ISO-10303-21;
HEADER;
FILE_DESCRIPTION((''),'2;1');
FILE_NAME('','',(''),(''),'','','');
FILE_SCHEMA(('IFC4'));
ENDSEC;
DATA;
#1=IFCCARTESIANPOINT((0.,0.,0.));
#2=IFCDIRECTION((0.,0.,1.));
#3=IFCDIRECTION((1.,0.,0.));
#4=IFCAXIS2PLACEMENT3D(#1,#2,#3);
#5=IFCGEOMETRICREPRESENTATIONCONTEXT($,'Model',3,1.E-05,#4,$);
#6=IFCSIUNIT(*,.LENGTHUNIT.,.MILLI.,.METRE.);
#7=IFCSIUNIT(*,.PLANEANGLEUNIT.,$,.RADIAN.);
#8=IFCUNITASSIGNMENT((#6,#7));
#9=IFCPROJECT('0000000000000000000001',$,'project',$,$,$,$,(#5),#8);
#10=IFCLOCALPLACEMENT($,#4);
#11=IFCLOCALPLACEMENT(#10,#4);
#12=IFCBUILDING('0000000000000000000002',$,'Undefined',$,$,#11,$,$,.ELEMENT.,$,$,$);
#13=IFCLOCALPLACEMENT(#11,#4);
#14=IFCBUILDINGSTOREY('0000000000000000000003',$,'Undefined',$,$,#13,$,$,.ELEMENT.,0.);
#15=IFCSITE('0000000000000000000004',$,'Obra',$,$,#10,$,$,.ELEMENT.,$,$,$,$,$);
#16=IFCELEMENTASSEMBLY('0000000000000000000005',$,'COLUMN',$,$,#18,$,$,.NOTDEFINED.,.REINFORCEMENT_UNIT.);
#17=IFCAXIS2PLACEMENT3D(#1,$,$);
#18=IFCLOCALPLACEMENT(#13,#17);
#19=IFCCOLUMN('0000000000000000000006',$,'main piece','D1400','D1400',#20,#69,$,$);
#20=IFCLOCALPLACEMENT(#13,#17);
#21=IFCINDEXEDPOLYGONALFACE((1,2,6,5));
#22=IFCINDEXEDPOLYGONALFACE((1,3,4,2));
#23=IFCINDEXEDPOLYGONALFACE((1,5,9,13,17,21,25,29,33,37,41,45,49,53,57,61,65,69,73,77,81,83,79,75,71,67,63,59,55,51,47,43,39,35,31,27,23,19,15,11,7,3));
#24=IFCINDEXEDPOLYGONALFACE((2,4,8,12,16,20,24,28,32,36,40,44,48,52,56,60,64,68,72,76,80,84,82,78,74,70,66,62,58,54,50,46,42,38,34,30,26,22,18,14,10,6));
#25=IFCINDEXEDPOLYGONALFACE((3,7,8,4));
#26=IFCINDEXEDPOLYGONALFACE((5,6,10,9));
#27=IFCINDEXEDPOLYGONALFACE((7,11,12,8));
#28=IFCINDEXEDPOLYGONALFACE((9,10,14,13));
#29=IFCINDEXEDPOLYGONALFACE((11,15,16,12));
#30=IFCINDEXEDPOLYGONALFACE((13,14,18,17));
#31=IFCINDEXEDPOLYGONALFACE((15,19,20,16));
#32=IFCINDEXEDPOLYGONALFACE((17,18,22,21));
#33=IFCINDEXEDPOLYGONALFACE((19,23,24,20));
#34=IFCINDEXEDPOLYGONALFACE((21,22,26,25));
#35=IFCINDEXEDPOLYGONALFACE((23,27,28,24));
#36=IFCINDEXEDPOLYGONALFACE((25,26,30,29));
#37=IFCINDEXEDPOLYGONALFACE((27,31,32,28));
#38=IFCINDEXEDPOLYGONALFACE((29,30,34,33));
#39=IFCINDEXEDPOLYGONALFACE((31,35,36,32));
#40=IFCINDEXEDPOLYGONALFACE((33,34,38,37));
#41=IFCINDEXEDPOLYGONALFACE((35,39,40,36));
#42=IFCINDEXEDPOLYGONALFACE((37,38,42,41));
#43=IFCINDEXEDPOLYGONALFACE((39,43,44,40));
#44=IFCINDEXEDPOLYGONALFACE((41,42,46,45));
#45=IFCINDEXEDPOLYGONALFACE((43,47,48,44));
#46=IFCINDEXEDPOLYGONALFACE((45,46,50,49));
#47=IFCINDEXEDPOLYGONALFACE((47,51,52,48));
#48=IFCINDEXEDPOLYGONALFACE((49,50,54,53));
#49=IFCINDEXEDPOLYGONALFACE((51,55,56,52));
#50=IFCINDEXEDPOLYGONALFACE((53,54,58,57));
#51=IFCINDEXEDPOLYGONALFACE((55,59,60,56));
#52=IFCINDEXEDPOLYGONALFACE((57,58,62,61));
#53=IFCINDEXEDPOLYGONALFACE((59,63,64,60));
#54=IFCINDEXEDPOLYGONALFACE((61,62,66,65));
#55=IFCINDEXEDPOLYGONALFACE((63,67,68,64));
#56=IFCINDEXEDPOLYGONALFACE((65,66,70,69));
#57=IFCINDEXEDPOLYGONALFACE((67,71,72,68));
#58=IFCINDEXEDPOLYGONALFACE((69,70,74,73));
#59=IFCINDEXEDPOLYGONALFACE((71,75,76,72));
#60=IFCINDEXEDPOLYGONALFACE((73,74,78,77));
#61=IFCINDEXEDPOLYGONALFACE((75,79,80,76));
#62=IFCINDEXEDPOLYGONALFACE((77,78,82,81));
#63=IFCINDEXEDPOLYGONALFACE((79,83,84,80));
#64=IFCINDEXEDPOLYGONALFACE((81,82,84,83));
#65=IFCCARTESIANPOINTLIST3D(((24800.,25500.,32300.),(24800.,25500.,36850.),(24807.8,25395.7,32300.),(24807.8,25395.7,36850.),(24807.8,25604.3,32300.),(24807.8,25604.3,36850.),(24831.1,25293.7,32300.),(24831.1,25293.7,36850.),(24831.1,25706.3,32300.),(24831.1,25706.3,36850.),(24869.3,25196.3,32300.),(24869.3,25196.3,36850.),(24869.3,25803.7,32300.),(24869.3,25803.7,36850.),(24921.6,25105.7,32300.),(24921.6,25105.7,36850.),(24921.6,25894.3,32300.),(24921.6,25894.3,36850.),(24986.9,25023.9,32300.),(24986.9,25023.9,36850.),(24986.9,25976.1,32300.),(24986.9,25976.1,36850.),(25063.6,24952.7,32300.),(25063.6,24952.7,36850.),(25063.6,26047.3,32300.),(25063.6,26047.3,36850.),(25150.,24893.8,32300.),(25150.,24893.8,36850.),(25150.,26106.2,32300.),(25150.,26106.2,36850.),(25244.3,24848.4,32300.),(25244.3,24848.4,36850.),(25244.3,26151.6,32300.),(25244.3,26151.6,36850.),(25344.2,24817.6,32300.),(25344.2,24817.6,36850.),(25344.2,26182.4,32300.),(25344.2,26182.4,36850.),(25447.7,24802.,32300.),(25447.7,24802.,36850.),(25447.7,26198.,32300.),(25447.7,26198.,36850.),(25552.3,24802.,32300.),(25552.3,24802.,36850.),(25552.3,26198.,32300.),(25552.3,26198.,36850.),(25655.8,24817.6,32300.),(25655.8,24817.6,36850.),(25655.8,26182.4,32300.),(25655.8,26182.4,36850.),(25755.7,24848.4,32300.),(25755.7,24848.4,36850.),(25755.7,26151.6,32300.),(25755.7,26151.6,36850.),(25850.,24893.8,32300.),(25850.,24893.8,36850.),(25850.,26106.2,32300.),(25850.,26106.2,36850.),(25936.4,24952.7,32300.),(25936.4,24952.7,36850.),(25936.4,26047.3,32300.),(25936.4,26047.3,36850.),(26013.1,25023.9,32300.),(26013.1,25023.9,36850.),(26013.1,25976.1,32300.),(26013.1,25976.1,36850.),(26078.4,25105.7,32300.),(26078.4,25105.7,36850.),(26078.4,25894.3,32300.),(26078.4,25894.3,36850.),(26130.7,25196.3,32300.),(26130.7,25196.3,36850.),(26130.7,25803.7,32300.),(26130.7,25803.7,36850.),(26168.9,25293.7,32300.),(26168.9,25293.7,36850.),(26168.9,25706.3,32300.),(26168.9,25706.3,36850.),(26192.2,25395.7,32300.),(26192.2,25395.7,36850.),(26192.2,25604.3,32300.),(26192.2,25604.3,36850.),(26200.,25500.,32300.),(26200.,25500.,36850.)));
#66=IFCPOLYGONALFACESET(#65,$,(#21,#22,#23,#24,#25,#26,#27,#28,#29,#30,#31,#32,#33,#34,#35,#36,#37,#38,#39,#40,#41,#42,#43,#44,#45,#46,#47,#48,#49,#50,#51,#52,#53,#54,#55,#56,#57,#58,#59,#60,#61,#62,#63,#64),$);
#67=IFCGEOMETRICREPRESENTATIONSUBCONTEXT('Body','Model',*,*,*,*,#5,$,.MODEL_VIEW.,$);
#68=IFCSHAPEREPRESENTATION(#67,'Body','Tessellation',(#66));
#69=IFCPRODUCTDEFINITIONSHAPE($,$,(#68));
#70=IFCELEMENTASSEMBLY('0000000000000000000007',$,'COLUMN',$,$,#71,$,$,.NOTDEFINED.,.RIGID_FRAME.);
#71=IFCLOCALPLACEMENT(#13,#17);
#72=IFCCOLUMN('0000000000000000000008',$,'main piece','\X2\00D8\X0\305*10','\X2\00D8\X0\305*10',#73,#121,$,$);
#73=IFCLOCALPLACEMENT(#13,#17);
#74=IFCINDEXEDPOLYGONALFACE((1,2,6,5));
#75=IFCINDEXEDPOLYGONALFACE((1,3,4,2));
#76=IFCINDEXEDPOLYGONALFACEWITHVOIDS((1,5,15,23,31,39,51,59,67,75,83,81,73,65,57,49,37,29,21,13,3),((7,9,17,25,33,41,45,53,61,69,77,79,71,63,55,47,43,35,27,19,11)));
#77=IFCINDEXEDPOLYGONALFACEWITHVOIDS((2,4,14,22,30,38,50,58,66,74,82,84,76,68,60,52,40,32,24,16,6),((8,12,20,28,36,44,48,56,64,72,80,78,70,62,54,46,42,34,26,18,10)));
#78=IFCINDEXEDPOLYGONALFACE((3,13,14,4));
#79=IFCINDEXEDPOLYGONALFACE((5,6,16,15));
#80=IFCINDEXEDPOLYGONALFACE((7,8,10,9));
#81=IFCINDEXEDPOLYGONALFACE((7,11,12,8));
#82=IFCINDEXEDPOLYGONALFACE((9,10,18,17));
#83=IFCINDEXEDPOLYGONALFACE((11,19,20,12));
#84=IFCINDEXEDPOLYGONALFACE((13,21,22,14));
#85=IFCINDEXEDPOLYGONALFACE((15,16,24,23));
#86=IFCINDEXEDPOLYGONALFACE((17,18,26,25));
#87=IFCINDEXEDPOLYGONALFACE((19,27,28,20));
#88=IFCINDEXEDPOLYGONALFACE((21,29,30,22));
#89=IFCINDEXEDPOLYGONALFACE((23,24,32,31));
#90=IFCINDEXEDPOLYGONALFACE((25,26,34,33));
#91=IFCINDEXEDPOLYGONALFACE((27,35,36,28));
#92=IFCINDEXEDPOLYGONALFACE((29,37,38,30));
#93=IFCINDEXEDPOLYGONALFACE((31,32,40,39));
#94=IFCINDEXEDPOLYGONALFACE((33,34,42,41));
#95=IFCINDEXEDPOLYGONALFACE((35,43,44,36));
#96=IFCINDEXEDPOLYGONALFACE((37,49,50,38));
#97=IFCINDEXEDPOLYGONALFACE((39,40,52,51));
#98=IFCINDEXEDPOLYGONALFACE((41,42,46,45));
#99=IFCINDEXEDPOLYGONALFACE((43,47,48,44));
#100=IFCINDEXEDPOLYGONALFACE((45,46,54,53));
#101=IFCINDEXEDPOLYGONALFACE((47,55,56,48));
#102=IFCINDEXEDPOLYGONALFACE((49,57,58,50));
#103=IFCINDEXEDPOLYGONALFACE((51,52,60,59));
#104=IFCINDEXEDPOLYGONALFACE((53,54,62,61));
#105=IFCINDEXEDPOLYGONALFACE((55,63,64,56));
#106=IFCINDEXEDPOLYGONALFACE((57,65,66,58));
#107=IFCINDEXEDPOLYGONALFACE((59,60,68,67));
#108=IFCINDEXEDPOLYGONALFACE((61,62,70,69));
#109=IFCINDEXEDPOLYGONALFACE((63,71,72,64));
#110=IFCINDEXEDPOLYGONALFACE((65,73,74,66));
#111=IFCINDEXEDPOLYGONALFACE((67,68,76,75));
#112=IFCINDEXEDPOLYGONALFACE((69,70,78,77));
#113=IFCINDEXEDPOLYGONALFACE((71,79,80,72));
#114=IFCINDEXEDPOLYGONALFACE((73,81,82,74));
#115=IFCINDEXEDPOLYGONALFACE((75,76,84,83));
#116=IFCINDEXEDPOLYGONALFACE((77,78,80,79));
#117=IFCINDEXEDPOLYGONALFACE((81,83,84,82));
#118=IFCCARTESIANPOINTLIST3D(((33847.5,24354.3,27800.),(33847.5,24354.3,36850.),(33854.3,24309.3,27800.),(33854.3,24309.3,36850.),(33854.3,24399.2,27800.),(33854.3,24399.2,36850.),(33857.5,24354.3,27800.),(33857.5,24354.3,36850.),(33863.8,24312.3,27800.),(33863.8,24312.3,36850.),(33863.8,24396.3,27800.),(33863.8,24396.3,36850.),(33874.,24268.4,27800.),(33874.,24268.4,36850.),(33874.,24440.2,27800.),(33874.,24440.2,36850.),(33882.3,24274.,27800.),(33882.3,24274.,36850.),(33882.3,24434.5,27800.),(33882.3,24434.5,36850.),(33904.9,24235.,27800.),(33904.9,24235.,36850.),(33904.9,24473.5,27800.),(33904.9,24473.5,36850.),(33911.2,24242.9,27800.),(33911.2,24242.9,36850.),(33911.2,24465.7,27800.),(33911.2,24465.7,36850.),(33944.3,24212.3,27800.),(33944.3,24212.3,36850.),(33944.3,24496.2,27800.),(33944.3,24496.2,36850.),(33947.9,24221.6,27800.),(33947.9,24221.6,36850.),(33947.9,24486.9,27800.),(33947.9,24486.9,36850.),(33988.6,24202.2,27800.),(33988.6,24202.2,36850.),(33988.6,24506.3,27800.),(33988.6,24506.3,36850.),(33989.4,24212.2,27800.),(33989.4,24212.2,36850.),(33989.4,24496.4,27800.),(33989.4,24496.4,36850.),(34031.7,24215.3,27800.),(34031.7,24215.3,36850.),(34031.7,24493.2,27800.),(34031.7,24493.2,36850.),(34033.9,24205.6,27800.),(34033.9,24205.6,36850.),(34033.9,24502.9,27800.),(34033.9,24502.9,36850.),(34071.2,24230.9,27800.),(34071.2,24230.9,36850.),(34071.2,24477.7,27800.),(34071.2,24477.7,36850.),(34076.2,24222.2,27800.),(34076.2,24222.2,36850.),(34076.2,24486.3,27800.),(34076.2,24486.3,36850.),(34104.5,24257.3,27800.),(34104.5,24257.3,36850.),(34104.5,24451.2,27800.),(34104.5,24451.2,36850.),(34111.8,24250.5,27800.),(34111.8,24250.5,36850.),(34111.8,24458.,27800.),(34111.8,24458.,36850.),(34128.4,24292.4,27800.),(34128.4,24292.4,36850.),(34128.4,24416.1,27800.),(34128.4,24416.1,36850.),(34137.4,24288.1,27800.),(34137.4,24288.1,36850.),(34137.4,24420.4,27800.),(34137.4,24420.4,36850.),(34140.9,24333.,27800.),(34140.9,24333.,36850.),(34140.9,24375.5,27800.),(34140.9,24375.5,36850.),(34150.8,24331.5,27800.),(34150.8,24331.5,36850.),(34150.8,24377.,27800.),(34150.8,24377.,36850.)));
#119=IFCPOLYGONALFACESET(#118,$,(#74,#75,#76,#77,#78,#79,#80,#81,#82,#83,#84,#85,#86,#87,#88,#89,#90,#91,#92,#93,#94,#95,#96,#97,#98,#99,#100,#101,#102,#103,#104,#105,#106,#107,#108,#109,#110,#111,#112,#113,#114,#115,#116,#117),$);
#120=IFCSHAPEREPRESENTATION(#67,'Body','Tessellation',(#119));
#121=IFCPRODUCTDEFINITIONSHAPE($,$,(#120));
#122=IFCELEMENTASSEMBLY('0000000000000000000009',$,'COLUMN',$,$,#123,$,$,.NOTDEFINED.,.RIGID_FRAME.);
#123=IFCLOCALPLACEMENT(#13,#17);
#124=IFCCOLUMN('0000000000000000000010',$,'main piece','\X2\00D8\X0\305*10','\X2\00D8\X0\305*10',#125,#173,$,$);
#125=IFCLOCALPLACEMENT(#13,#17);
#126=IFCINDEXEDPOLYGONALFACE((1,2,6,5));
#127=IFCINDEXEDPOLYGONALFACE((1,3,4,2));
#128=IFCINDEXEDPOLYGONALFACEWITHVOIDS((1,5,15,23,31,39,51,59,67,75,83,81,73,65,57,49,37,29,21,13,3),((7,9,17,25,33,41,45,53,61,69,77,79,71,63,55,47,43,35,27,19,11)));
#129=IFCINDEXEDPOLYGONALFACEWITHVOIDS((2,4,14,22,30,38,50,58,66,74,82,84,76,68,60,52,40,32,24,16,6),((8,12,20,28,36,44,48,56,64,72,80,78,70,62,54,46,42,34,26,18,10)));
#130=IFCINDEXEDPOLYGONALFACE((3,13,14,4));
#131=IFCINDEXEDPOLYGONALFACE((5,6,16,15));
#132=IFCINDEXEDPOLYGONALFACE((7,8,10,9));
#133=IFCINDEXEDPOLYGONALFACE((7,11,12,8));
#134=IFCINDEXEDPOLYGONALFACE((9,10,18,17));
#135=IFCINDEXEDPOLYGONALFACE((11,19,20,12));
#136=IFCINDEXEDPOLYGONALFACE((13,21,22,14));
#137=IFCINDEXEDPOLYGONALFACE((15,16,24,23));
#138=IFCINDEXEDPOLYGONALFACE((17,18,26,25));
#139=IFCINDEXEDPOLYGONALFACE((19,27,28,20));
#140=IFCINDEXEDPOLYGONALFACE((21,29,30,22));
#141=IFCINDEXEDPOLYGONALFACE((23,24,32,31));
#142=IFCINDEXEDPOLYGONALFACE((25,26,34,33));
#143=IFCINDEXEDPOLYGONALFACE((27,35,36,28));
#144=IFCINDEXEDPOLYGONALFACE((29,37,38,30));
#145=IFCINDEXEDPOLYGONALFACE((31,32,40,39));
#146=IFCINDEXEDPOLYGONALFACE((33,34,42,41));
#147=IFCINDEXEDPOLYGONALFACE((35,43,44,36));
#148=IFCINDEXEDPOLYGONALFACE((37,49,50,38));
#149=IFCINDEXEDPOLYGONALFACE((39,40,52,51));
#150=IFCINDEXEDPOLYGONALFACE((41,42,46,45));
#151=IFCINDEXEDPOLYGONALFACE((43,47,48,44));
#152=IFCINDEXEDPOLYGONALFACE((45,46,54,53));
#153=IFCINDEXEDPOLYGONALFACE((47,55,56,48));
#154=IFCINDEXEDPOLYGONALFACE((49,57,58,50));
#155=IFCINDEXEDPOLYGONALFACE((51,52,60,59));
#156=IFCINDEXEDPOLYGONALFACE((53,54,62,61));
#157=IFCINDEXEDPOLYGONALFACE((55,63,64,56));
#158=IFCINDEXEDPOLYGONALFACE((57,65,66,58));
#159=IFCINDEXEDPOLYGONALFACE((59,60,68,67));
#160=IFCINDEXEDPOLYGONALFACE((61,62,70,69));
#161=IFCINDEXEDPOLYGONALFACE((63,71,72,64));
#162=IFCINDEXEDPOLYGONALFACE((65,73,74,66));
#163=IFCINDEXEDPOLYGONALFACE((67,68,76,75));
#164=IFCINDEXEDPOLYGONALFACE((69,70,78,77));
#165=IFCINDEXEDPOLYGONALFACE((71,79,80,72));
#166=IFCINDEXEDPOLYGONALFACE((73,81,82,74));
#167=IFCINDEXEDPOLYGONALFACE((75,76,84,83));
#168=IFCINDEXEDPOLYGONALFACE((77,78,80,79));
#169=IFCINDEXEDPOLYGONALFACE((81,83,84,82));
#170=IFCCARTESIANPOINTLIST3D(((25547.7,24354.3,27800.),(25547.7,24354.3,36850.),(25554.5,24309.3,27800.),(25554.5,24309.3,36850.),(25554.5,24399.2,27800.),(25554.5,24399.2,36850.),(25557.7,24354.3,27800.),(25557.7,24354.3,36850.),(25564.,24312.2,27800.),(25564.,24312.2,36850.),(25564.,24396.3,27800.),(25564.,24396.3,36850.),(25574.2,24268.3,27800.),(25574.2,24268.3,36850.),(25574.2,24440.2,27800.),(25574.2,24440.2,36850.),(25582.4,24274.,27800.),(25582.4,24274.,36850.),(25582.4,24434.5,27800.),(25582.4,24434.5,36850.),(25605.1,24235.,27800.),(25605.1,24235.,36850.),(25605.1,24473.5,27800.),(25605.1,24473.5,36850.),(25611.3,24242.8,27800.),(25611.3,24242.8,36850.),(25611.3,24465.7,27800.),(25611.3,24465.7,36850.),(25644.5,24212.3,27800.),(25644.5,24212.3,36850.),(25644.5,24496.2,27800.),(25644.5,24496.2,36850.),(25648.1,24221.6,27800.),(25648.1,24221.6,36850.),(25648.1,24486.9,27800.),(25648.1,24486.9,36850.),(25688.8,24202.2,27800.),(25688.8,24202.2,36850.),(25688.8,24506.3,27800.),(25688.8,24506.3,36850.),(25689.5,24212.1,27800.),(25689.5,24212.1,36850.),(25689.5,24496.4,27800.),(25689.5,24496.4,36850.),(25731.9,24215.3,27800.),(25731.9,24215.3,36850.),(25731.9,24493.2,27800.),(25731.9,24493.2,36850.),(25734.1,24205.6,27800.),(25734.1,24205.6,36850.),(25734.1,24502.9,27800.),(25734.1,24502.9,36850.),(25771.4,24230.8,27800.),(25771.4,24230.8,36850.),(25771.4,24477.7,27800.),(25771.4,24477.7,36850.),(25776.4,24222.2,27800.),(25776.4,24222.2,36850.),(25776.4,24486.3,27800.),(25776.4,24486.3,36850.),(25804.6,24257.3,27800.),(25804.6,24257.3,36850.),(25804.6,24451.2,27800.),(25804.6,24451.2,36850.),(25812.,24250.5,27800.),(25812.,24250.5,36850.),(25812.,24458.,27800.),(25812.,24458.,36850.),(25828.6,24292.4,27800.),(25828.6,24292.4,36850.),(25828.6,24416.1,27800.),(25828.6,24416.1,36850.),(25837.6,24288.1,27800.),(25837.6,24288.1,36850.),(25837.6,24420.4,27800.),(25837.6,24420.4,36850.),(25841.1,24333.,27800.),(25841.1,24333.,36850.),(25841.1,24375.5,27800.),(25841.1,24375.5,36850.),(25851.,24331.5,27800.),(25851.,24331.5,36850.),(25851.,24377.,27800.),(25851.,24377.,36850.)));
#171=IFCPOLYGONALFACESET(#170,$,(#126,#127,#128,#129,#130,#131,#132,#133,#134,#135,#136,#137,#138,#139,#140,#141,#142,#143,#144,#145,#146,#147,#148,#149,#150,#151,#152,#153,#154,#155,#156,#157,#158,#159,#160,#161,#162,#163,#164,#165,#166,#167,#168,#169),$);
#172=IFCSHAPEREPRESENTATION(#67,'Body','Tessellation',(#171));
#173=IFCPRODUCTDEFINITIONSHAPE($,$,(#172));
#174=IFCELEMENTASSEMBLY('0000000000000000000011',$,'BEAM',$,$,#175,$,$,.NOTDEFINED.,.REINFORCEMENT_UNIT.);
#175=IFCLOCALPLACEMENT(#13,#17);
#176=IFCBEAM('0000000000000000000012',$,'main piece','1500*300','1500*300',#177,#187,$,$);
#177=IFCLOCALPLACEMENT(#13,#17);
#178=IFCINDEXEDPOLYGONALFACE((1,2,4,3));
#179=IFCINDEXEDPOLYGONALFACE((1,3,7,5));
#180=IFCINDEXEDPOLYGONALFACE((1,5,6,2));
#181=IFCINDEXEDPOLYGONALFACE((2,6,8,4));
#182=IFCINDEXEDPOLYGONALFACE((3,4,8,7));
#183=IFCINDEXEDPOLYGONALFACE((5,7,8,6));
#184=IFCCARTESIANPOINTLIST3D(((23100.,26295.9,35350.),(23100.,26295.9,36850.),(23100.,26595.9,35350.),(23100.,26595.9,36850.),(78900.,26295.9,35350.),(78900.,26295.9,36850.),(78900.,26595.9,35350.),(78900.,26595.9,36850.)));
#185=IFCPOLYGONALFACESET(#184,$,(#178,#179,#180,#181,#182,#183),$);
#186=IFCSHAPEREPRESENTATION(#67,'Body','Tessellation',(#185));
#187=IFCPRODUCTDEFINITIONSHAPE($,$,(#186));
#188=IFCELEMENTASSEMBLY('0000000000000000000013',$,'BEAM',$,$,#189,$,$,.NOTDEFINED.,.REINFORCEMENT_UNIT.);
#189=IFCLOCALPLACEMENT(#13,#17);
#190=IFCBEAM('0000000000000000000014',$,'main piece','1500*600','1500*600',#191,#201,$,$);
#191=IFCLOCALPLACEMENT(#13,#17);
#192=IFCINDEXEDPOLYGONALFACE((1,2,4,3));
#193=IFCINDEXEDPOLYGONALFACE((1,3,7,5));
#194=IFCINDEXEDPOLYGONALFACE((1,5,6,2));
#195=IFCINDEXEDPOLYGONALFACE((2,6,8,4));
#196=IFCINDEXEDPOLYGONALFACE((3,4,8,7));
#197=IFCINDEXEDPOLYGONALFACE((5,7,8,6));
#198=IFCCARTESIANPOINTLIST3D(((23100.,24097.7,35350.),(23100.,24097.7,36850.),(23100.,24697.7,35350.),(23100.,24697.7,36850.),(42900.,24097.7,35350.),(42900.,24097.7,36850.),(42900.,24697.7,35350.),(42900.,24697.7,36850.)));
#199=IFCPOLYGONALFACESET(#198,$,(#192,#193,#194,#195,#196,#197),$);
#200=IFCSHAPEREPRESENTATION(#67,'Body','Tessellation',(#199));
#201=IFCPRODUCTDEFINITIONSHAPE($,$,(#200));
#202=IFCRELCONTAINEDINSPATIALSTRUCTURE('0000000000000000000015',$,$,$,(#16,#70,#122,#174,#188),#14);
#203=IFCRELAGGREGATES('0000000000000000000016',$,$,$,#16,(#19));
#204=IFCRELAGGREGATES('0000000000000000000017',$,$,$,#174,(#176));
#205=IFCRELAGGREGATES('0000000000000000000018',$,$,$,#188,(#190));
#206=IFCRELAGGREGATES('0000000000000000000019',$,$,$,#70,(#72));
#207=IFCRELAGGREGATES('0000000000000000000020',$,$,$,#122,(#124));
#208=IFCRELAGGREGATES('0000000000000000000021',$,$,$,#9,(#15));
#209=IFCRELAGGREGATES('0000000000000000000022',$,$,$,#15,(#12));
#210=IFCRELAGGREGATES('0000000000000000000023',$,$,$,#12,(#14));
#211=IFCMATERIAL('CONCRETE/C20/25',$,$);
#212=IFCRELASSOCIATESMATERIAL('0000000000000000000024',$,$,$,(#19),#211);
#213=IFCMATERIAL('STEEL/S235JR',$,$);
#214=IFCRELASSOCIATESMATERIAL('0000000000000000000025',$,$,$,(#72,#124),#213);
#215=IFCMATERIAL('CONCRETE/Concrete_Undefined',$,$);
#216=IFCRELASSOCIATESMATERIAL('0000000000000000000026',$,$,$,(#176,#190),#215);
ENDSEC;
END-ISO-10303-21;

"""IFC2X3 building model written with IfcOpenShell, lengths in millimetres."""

from ifc_helpers import new_model, si_unit, frame, origin_with_axes, origin_2d_with_axis, place, context, subcontext, project, spatial, rectangle, circle, hollow_circle, extrude, material, element, aggregate, save


model = new_model("IFC2X3")

# Units and contexts
model_context = context("Model", 3, precision=1e-05, world=origin_with_axes())
body_context = subcontext(model_context, "Body", "Model", "MODEL_VIEW")
ifc_project = project(units=[si_unit("LENGTHUNIT", "METRE", prefix="MILLI"), si_unit("PLANEANGLEUNIT", "RADIAN")], contexts=[model_context])

# Site, building, storey
site_placement = place(None, origin_with_axes())
site = spatial("IfcSite", under=ifc_project, at=site_placement, Name="Obra", CompositionType="ELEMENT")
building_placement = place(site_placement, origin_with_axes())
building = spatial("IfcBuilding", under=site, at=building_placement, Name="Undefined", CompositionType="ELEMENT")
storey_placement = place(building_placement, origin_with_axes())
storey = spatial("IfcBuildingStorey", under=building, at=storey_placement, Name="Undefined", CompositionType="ELEMENT", Elevation=0.0)

# Element assemblies, columns
assembly_1_placement = place(storey_placement, origin_with_axes())
assembly_1 = element("IfcElementAssembly", 1, at=assembly_1_placement, inside=storey, Name="COLUMN", AssemblyPlace="NOTDEFINED", PredefinedType="REINFORCEMENT_UNIT")
ifc_material_1 = material(Name="CONCRETE/C20/25")
column_1_placement = place(assembly_1_placement, frame((25500.0, 25500.0, 32300.0), z_axis=(0.0, 0.0, 1.0), x_axis=(0.0, 1.0, 0.0)))
column_1 = element("IfcColumn", 2, at=column_1_placement, material=ifc_material_1, Name="main piece", Description="D1400", ObjectType="D1400", context=body_context, shape_type="SweptSolid", body=[
    extrude(circle(Radius=700.0, at=origin_2d_with_axis()), frame((0.0, 0.0, 4550.0), z_axis=(0.0, 0.0, -1.0), x_axis=(0.0, 1.0, 0.0)), (0.0, 0.0, 1.0), 4550.0),
])
aggregate(assembly_1, [column_1])
assembly_2_placement = place(storey_placement, origin_with_axes())
assembly_2 = element("IfcElementAssembly", 3, at=assembly_2_placement, inside=storey, Name="COLUMN", AssemblyPlace="NOTDEFINED", PredefinedType="RIGID_FRAME")
ifc_material_2 = material(Name="STEEL/S235JR")
column_2_placement = place(assembly_2_placement, frame((34000.0, 24354.3, 27800.0), z_axis=(0.0, 0.0, 1.0), x_axis=(0.0, 1.0, 0.0)))
column_2 = element("IfcColumn", 4, at=column_2_placement, material=ifc_material_2, Name="main piece", Description="Ø305*10", ObjectType="Ø305*10", context=body_context, shape_type="SweptSolid", body=[
    extrude(hollow_circle(Radius=152.5, WallThickness=10.0, at=origin_2d_with_axis()), frame((0.0, 0.0, 9050.0), z_axis=(0.0, 0.0, -1.0), x_axis=(0.0, 1.0, 0.0)), (0.0, 0.0, 1.0), 9050.0),
])
assembly_3_placement = place(storey_placement, origin_with_axes())
assembly_3 = element("IfcElementAssembly", 5, at=assembly_3_placement, inside=storey, Name="COLUMN", AssemblyPlace="NOTDEFINED", PredefinedType="RIGID_FRAME")
column_3_placement = place(assembly_3_placement, frame((25700.2, 24354.3, 27800.0), z_axis=(0.0, 0.0, 1.0), x_axis=(0.0, 1.0, 0.0)))
column_3 = element("IfcColumn", 6, at=column_3_placement, material=ifc_material_2, Name="main piece", Description="Ø305*10", ObjectType="Ø305*10", context=body_context, shape_type="SweptSolid", body=[
    extrude(hollow_circle(Radius=152.5, WallThickness=10.0, at=origin_2d_with_axis()), frame((0.0, 0.0, 9050.0), z_axis=(0.0, 0.0, -1.0), x_axis=(0.0, 1.0, 0.0)), (0.0, 0.0, 1.0), 9050.0),
])

# Element assemblies, beams
assembly_4_placement = place(storey_placement, origin_with_axes())
assembly_4 = element("IfcElementAssembly", 7, at=assembly_4_placement, inside=storey, Name="BEAM", AssemblyPlace="NOTDEFINED", PredefinedType="REINFORCEMENT_UNIT")
ifc_material_3 = material(Name="CONCRETE/Concrete_Undefined")
beam_1_placement = place(assembly_4_placement, frame((23100.0, 26445.9, 36100.0), z_axis=(0.0, 0.0, 1.0), x_axis=(1.0, 0.0, 0.0)))
beam_1 = element("IfcBeam", 8, at=beam_1_placement, material=ifc_material_3, Name="main piece", Description="1500*300", ObjectType="1500*300", context=body_context, shape_type="SweptSolid", body=[
    extrude(rectangle(XDim=300.0, YDim=1500.0, at=origin_2d_with_axis()), frame((55800.0, 0.0, 0.0), z_axis=(-1.0, 0.0, 0.0), x_axis=(0.0, -1.0, 0.0)), (0.0, 0.0, 1.0), 55800.0),
])
aggregate(assembly_4, [beam_1])
assembly_5_placement = place(storey_placement, origin_with_axes())
assembly_5 = element("IfcElementAssembly", 9, at=assembly_5_placement, inside=storey, Name="BEAM", AssemblyPlace="NOTDEFINED", PredefinedType="REINFORCEMENT_UNIT")
beam_2_placement = place(assembly_5_placement, frame((23100.0, 24397.7, 36100.0), z_axis=(0.0, 0.0, 1.0), x_axis=(1.0, 0.0, 0.0)))
beam_2 = element("IfcBeam", 10, at=beam_2_placement, material=ifc_material_3, Name="main piece", Description="1500*600", ObjectType="1500*600", context=body_context, shape_type="SweptSolid", body=[
    extrude(rectangle(XDim=600.0, YDim=1500.0, at=origin_2d_with_axis()), frame((19800.0, 0.0, 0.0), z_axis=(-1.0, 0.0, 0.0), x_axis=(0.0, -1.0, 0.0)), (0.0, 0.0, 1.0), 19800.0),
])
aggregate(assembly_5, [beam_2])

aggregate(assembly_2, [column_2])
aggregate(assembly_3, [column_3])

save(model, "model.ifc")
